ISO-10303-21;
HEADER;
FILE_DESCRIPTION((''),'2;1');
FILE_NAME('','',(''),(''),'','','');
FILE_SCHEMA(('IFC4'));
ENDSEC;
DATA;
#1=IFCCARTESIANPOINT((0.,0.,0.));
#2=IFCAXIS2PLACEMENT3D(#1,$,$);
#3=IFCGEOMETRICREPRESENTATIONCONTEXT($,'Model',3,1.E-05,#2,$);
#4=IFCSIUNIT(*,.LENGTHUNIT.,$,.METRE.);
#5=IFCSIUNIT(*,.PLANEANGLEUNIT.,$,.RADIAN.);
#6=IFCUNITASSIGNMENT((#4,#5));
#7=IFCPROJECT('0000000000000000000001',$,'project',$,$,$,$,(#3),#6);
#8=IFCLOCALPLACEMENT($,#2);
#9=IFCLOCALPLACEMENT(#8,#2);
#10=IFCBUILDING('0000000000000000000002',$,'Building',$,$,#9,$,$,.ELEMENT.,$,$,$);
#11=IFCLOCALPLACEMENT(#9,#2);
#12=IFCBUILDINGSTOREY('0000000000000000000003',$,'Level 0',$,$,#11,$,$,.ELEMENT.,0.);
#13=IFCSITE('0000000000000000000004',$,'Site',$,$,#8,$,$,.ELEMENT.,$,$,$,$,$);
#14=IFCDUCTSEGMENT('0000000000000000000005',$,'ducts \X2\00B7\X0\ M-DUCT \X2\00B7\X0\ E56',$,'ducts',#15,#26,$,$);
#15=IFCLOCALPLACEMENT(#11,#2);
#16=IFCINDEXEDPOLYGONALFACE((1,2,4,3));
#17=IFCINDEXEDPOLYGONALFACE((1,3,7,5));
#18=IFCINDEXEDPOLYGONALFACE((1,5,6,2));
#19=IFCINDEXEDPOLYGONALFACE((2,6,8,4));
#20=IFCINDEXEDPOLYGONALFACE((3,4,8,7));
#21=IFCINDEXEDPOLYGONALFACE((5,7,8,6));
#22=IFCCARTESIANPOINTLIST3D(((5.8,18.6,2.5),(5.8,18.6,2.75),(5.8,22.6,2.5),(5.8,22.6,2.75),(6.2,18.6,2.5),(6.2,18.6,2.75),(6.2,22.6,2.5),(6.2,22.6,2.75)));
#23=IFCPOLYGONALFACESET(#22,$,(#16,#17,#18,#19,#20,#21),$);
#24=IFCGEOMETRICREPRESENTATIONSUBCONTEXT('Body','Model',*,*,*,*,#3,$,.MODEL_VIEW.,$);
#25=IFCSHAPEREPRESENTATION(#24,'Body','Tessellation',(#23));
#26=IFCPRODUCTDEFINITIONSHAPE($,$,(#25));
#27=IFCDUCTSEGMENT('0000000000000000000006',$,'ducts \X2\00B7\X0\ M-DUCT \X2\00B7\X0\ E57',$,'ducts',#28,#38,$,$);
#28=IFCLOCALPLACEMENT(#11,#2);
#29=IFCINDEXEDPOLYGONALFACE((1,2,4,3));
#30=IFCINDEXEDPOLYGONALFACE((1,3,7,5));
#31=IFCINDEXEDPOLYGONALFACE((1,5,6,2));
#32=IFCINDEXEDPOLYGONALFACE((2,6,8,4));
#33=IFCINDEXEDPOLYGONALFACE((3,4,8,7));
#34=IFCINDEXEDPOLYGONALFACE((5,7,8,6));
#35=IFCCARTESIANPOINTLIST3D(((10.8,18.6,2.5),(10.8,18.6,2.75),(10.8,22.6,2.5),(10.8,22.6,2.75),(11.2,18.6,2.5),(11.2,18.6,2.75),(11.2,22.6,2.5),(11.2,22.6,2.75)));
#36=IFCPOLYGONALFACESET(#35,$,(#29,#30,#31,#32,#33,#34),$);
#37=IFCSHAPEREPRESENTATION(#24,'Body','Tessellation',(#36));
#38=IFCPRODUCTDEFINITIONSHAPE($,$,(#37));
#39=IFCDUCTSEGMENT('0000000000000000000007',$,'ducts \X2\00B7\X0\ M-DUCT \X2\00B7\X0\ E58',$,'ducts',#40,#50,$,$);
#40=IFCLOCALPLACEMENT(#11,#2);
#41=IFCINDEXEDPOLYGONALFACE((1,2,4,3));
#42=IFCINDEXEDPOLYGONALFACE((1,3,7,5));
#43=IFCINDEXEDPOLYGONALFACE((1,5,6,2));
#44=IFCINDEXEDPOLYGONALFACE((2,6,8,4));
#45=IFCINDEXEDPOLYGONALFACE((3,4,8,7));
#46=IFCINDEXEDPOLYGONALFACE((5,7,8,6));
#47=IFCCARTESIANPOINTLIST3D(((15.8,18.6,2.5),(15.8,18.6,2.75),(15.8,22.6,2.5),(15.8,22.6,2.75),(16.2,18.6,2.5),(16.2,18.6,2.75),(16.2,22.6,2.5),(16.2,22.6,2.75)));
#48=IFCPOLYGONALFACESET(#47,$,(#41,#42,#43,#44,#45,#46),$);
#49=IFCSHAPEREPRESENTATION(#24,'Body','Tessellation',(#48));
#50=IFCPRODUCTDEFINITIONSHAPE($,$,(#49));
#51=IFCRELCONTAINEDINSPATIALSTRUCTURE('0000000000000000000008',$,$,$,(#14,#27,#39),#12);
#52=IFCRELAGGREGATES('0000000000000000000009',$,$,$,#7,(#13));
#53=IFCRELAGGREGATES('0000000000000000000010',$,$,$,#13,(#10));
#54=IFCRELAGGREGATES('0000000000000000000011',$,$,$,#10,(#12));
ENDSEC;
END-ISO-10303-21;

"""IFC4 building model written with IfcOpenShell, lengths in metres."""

from ifc_helpers import new_model, si_unit, frame, origin, place, context, subcontext, project, spatial, polyline, outline, extrude, element, save


model = new_model("IFC4")

# Units and contexts
model_context = context("Model", 3, precision=1e-05, world=origin())
body_context = subcontext(model_context, "Body", "Model", "MODEL_VIEW")
ifc_project = project(units=[si_unit("LENGTHUNIT", "METRE"), si_unit("PLANEANGLEUNIT", "RADIAN")], contexts=[model_context])

# Site, building, storey
site_placement = place(None, origin())
site = spatial("IfcSite", under=ifc_project, at=site_placement, Name="Site", CompositionType="ELEMENT")
building_placement = place(site_placement, origin())
building = spatial("IfcBuilding", under=site, at=building_placement, Name="Building", CompositionType="ELEMENT")
storey_placement = place(building_placement, origin())
storey = spatial("IfcBuildingStorey", under=building, at=storey_placement, Name="Level 0", CompositionType="ELEMENT", Elevation=0.0)

# Duct segments
duct_segment_1_placement = place(storey_placement, frame((0.0, 0.0, 2.5)))
element("IfcDuctSegment", 1, at=duct_segment_1_placement, inside=storey, Name="ducts · M-DUCT · E56", ObjectType="ducts", context=body_context, shape_type="SweptSolid", body=[
    extrude(outline(polyline([(5.8, 22.6), (5.8, 18.6), (6.2, 18.6), (6.2, 22.6), (5.8, 22.6)])), origin(), (0.0, 0.0, 1.0), 0.25),
])
duct_segment_2_placement = place(storey_placement, frame((0.0, 0.0, 2.5)))
element("IfcDuctSegment", 2, at=duct_segment_2_placement, inside=storey, Name="ducts · M-DUCT · E57", ObjectType="ducts", context=body_context, shape_type="SweptSolid", body=[
    extrude(outline(polyline([(10.8, 22.6), (10.8, 18.6), (11.2, 18.6), (11.2, 22.6), (10.8, 22.6)])), origin(), (0.0, 0.0, 1.0), 0.25),
])
duct_segment_3_placement = place(storey_placement, frame((0.0, 0.0, 2.5)))
element("IfcDuctSegment", 3, at=duct_segment_3_placement, inside=storey, Name="ducts · M-DUCT · E58", ObjectType="ducts", context=body_context, shape_type="SweptSolid", body=[
    extrude(outline(polyline([(15.8, 22.6), (15.8, 18.6), (16.2, 18.6), (16.2, 22.6), (15.8, 22.6)])), origin(), (0.0, 0.0, 1.0), 0.25),
])

save(model, "model.ifc")
